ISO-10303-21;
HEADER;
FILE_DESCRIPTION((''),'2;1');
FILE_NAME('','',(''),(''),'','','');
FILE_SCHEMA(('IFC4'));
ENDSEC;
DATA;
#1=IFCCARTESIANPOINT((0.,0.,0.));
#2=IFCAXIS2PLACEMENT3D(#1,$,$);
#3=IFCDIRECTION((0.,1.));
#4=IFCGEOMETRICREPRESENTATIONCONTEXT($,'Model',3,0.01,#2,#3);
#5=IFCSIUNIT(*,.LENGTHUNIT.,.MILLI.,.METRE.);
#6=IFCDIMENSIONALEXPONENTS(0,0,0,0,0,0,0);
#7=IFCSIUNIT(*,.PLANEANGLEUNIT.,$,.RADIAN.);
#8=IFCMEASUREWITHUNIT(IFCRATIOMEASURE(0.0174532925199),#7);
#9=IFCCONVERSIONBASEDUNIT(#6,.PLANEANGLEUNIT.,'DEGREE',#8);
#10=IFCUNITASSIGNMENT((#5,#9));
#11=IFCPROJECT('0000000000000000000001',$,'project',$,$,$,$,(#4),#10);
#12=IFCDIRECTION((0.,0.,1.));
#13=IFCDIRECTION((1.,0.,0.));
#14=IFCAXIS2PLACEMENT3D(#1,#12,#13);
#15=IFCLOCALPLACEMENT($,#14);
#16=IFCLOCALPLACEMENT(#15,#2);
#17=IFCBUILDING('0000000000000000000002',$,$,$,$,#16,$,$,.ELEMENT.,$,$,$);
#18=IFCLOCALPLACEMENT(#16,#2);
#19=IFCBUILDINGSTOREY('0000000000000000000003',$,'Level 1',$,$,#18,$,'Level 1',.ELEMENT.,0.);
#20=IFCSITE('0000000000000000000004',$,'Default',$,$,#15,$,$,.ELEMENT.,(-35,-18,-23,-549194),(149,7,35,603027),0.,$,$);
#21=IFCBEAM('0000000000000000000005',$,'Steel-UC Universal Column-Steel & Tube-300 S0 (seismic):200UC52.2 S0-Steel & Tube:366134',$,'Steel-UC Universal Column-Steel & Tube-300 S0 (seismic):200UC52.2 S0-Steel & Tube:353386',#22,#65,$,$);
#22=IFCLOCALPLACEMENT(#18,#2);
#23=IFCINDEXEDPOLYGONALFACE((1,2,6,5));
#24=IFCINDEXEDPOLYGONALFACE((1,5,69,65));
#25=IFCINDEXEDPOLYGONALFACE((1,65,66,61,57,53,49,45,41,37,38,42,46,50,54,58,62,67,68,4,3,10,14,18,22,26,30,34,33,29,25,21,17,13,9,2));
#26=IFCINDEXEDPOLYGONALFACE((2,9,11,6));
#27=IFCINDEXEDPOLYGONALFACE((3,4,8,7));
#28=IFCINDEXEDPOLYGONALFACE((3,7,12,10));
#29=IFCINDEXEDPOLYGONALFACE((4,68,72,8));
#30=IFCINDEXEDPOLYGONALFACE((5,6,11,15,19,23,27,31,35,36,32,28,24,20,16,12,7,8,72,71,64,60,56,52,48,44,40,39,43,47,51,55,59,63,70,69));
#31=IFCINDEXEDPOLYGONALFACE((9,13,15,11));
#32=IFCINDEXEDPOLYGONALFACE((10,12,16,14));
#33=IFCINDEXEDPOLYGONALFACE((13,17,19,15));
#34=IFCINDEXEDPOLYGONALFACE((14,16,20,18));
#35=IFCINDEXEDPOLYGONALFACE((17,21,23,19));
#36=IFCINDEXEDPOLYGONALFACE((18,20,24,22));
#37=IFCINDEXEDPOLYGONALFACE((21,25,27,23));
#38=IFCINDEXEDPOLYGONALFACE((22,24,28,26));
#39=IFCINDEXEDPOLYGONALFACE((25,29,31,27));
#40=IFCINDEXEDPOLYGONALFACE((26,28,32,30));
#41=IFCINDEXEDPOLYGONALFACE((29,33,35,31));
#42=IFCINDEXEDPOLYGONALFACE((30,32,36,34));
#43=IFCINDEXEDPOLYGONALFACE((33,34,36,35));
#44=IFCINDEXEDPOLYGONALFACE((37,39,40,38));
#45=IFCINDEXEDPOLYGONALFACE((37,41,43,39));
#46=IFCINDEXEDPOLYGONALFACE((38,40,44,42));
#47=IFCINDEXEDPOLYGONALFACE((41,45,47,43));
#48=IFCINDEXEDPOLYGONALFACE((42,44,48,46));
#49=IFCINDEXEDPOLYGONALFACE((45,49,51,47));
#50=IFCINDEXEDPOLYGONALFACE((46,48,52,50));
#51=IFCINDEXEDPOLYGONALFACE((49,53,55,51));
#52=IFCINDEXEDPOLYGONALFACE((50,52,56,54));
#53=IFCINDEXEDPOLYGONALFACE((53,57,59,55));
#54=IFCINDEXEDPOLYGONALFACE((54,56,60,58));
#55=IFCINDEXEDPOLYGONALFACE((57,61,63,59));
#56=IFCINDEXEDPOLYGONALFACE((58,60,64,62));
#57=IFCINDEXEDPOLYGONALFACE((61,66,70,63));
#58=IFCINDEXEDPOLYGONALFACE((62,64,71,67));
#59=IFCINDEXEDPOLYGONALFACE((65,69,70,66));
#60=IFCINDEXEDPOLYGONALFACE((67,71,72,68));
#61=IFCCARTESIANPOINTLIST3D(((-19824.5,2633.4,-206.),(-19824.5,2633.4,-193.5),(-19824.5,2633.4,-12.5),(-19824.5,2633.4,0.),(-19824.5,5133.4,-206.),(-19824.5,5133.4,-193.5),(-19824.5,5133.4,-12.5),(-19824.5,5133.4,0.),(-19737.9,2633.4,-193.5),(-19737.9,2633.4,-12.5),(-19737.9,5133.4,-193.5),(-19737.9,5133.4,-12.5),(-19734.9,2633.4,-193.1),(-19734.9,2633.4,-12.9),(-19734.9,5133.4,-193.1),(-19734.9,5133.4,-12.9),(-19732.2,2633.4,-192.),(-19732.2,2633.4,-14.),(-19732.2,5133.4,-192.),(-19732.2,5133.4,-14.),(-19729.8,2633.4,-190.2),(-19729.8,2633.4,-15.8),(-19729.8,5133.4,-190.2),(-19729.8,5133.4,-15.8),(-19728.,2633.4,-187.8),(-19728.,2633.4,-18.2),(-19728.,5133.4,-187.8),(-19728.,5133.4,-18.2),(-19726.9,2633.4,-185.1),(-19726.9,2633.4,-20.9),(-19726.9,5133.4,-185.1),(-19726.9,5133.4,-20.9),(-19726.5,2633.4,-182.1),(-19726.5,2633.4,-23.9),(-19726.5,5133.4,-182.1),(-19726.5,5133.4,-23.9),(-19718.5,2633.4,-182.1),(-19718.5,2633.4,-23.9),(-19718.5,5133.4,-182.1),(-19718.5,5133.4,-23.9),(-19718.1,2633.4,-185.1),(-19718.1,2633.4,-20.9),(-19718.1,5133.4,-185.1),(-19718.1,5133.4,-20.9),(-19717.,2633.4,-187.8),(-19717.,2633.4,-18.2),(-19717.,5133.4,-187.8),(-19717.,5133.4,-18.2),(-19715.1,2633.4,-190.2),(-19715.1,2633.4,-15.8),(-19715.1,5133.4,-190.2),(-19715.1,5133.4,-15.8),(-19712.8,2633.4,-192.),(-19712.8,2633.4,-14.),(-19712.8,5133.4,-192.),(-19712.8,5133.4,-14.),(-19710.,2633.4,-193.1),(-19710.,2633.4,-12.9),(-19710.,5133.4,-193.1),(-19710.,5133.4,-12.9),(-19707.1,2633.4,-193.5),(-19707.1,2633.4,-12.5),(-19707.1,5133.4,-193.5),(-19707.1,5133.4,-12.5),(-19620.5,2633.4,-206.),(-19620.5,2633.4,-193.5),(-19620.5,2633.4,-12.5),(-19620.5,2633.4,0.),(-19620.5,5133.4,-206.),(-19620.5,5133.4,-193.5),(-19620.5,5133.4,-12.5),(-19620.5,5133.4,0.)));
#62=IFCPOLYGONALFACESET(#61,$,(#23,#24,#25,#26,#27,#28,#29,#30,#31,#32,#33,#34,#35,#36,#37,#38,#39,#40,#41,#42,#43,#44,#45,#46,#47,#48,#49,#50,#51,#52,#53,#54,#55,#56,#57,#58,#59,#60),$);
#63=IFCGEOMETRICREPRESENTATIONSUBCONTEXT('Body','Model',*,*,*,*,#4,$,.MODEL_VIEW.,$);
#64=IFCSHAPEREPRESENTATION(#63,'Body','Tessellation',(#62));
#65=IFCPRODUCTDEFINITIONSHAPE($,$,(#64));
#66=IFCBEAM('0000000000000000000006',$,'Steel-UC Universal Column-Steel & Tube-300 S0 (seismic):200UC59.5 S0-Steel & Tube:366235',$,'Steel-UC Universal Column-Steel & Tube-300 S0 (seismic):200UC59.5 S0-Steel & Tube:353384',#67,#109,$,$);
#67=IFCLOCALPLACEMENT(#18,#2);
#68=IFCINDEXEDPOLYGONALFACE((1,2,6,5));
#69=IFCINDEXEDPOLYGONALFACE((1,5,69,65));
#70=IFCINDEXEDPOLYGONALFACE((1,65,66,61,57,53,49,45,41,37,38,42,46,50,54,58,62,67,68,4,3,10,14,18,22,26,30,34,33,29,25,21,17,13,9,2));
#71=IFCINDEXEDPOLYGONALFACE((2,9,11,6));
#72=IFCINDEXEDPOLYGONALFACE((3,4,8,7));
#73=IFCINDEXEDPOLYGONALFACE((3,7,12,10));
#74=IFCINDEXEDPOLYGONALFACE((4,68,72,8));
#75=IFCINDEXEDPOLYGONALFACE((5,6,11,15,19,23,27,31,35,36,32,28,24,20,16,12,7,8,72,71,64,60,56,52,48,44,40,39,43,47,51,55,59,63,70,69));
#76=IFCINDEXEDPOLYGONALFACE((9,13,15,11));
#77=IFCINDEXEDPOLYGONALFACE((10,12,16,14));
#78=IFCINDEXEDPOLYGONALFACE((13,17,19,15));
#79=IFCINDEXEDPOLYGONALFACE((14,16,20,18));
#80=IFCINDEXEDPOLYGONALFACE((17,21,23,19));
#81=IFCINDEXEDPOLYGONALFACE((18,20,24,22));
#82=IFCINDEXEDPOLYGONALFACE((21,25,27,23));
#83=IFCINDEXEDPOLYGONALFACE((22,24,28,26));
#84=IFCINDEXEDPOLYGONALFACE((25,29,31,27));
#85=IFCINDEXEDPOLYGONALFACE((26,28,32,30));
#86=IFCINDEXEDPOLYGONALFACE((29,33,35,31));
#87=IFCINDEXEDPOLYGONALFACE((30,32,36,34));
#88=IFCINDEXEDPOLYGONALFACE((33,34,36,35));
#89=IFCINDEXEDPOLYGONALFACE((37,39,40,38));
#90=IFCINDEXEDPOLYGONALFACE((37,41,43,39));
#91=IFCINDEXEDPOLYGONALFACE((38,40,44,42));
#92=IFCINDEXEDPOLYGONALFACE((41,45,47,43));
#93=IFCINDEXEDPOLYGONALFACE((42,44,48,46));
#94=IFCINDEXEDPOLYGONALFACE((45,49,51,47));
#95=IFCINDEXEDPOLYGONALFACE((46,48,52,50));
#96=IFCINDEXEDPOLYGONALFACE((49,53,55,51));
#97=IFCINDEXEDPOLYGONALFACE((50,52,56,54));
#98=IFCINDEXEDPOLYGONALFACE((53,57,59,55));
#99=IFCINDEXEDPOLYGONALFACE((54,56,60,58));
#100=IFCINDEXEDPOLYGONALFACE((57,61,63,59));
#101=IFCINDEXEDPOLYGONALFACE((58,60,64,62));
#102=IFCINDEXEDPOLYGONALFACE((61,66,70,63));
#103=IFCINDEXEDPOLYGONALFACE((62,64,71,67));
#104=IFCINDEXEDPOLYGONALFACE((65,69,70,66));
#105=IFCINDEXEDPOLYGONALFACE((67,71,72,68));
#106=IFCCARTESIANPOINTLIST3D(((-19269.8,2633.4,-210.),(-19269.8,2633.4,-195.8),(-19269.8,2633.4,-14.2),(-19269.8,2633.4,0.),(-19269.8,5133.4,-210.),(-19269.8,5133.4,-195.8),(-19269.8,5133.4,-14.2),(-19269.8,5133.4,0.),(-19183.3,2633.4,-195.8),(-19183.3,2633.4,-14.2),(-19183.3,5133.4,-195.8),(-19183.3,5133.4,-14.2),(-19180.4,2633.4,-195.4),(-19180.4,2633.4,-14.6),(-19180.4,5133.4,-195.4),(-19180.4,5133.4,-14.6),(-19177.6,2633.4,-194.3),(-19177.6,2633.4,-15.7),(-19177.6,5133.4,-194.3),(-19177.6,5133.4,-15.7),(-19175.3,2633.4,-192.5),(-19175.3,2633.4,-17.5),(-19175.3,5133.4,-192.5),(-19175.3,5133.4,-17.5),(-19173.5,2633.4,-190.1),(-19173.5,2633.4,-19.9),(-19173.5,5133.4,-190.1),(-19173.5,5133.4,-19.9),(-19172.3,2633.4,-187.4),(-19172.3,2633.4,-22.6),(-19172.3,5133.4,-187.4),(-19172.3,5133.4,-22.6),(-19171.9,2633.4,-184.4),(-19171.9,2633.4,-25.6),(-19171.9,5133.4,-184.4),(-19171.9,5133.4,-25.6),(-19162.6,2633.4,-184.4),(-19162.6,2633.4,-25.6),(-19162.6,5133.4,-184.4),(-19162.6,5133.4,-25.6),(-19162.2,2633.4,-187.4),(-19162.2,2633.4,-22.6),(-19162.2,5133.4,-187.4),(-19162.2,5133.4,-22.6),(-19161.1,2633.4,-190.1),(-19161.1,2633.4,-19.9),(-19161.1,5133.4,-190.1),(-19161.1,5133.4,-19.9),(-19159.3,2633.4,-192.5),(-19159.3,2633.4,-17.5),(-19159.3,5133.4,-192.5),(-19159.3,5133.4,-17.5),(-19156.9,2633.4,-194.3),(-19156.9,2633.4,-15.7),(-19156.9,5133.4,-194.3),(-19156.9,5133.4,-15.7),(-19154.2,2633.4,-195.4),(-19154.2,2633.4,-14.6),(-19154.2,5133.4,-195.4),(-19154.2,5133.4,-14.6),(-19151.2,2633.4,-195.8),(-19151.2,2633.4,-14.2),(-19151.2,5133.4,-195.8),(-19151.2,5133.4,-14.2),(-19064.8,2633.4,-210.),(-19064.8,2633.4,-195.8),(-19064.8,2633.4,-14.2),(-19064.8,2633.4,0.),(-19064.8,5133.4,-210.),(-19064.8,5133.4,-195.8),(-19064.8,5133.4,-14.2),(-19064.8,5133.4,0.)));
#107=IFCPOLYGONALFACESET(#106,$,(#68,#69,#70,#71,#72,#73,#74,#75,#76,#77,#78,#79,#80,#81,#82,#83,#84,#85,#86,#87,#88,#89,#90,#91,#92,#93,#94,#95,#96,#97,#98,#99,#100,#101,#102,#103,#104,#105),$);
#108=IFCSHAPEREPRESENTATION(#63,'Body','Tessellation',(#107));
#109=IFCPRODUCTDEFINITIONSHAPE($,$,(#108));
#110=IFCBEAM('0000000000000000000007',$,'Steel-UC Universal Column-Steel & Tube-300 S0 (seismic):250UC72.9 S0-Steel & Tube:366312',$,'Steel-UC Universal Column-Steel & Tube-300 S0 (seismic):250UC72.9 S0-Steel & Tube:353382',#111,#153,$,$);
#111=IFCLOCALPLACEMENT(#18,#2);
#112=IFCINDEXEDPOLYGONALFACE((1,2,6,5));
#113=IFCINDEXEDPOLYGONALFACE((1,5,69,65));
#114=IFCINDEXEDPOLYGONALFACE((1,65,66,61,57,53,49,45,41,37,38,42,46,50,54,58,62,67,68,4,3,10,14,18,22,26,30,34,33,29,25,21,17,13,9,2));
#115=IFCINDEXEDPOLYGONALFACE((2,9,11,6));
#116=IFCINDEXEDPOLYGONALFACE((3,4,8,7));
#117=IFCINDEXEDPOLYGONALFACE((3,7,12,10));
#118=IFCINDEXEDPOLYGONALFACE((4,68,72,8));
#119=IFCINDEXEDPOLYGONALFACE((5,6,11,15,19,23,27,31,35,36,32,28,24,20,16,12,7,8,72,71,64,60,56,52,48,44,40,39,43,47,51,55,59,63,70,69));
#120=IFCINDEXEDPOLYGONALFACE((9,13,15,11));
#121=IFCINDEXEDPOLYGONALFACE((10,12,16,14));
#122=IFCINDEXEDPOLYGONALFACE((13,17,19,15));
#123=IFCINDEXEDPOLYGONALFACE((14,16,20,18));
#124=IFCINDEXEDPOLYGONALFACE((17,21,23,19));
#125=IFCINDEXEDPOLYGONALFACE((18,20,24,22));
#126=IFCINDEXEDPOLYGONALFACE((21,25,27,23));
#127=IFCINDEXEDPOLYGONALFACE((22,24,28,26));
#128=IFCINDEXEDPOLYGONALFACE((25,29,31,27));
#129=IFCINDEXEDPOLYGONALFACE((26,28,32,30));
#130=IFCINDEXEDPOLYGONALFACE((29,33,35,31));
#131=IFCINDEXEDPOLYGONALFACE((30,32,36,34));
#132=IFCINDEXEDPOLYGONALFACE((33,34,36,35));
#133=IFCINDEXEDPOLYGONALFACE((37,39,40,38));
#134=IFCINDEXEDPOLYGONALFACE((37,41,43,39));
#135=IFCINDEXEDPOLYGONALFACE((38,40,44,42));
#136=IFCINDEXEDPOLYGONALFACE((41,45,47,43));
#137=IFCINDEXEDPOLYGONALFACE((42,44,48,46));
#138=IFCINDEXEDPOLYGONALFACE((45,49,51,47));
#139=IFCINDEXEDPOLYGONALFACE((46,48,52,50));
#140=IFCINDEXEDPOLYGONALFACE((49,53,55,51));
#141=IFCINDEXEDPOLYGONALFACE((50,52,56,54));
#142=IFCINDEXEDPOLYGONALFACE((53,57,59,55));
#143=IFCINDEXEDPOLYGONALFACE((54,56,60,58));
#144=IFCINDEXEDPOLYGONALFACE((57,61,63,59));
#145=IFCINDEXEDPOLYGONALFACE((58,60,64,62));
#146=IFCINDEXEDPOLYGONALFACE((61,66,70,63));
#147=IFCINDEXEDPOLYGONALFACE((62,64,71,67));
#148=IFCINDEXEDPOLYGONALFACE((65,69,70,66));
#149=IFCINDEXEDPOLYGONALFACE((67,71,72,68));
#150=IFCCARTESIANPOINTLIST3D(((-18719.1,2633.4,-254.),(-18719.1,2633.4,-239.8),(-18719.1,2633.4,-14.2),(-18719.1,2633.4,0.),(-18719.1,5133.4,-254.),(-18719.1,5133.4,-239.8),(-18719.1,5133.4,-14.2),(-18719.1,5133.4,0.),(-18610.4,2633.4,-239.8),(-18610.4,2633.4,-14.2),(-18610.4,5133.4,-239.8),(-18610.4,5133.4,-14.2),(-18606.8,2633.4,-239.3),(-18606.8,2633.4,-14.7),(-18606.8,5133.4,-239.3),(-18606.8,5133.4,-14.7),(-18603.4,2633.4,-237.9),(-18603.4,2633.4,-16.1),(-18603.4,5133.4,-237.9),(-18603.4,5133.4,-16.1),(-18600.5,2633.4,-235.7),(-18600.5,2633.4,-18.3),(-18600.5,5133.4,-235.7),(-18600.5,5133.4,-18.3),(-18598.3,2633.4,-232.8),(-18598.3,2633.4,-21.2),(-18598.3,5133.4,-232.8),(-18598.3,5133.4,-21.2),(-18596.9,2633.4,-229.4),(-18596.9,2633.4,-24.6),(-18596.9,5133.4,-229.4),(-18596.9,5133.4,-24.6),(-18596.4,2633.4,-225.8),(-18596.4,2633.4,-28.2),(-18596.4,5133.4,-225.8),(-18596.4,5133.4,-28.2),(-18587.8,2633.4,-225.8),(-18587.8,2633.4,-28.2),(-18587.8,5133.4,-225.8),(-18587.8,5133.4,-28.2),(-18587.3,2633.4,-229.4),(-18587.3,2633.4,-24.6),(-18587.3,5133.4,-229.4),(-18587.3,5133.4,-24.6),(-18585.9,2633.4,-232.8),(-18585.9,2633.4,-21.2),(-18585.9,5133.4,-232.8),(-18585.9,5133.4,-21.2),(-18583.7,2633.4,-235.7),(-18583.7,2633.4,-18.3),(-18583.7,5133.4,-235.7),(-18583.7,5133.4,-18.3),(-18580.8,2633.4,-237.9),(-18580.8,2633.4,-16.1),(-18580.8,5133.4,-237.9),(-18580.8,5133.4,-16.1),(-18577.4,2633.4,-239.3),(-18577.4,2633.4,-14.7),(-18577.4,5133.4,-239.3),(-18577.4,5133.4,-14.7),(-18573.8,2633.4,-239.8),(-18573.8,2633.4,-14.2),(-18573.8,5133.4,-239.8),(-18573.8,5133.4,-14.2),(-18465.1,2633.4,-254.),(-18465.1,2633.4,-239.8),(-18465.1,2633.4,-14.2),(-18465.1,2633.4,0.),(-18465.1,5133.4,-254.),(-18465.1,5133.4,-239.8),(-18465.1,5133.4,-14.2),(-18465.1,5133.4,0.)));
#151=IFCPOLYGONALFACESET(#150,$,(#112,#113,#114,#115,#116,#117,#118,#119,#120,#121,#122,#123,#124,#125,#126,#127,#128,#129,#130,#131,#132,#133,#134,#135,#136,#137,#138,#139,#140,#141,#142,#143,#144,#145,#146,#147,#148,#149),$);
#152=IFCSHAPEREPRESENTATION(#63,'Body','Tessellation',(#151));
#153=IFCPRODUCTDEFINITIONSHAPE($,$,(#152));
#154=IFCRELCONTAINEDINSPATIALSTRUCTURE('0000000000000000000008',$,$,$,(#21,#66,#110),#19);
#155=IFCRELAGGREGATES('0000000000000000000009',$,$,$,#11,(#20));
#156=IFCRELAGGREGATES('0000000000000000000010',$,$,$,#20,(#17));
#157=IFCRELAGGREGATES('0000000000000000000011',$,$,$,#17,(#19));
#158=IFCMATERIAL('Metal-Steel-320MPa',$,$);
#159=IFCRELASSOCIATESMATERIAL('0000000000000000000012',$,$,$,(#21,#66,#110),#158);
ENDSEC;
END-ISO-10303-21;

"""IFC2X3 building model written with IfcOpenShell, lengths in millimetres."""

from ifc_helpers import new_model, entity, si_unit, converted_unit, direction, frame, frame_2d, origin, origin_with_axes, place, context, subcontext, project, spatial, polyline, circle_curve, parameter, trimmed, segment, composite_curve, outline, extrude, material, element, save


model = new_model("IFC2X3")

# Units and contexts
model_context = context("Model", 3, precision=0.01, world=origin(), true_north=direction((0.0, 1.0)))
body_context = subcontext(model_context, "Body", "Model", "MODEL_VIEW")
ifc_project = project(units=[si_unit("LENGTHUNIT", "METRE", prefix="MILLI"), converted_unit("PLANEANGLEUNIT", "DEGREE", entity("IfcRatioMeasure", 0.0174532925199), si_unit("PLANEANGLEUNIT", "RADIAN"), dimensions=[0, 0, 0, 0, 0, 0, 0])], contexts=[model_context])

# Site, building, storey
site_placement = place(None, origin_with_axes())
site = spatial("IfcSite", under=ifc_project, at=site_placement, Name="Default", CompositionType="ELEMENT", RefLatitude=(-35, -18, -23, -549194), RefLongitude=(149, 7, 35, 603027), RefElevation=0.0)
building_placement = place(site_placement, origin())
building = spatial("IfcBuilding", under=site, at=building_placement, CompositionType="ELEMENT")
storey_placement = place(building_placement, origin())
storey = spatial("IfcBuildingStorey", under=building, at=storey_placement, Name="Level 1", LongName="Level 1", CompositionType="ELEMENT", Elevation=0.0)

# Beams
ifc_material_1 = material(Name="Metal-Steel-320MPa")
beam_1_placement = place(storey_placement, frame((-19722.5, 5133.4, 0.0), z_axis=(0.0, 0.0, 1.0), x_axis=(0.0, -1.0, 0.0)))
element("IfcBeam", 1, at=beam_1_placement, inside=storey, material=ifc_material_1, Name="Steel-UC Universal Column-Steel & Tube-300 S0 (seismic):200UC52.2 S0-Steel & Tube:366134", ObjectType="Steel-UC Universal Column-Steel & Tube-300 S0 (seismic):200UC52.2 S0-Steel & Tube:353386", context=body_context, shape_type="SweptSolid", body=[
    extrude(outline(composite_curve([segment(polyline([(90.5, -102.0), (103.0, -102.0)]), True, "CONTINUOUS"), segment(polyline([(103.0, -102.0), (103.0, 102.0)]), True, "CONTINUOUS"), segment(polyline([(103.0, 102.0), (90.5, 102.0)]), True, "CONTINUOUS"), segment(polyline([(90.5, 102.0), (90.5, 15.4)]), True, "CONTINUOUS"), segment(trimmed(circle_curve(frame_2d((79.1, 15.4), x_axis=(1.0, 0.0)), 11.4), [parameter(270.0)], [parameter(0.0)], True, "PARAMETER"), False, "CONTINUOUS"), segment(polyline([(79.1, 4.0), (-79.1, 4.0)]), True, "CONTINUOUS"), segment(trimmed(circle_curve(frame_2d((-79.1, 15.4), x_axis=(0.0, -1.0)), 11.4), [parameter(270.0)], [parameter(0.0)], True, "PARAMETER"), False, "CONTINUOUS"), segment(polyline([(-90.5, 15.4), (-90.5, 102.0)]), True, "CONTINUOUS"), segment(polyline([(-90.5, 102.0), (-103.0, 102.0)]), True, "CONTINUOUS"), segment(polyline([(-103.0, 102.0), (-103.0, -102.0)]), True, "CONTINUOUS"), segment(polyline([(-103.0, -102.0), (-90.5, -102.0)]), True, "CONTINUOUS"), segment(polyline([(-90.5, -102.0), (-90.5, -15.4)]), True, "CONTINUOUS"), segment(trimmed(circle_curve(frame_2d((-79.1, -15.4), x_axis=(-1.0, 0.0)), 11.4), [parameter(270.0)], [parameter(0.0)], True, "PARAMETER"), False, "CONTINUOUS"), segment(polyline([(-79.1, -4.0), (79.1, -4.0)]), True, "CONTINUOUS"), segment(trimmed(circle_curve(frame_2d((79.1, -15.4), x_axis=(0.0, 1.0)), 11.4), [parameter(270.0)], [parameter(0.0)], True, "PARAMETER"), False, "CONTINUOUS"), segment(polyline([(90.5, -15.4), (90.5, -102.0)]), True, "CONTINUOUS")], self_intersect=False)), frame((0.0, 0.0, -103.0), z_axis=(1.0, 0.0, 0.0), x_axis=(0.0, 0.0, -1.0)), (0.0, 0.0, 1.0), 2500.0),
])
beam_2_placement = place(storey_placement, frame((-19167.3, 5133.4, 0.0), z_axis=(0.0, 0.0, 1.0), x_axis=(0.0, -1.0, 0.0)))
element("IfcBeam", 2, at=beam_2_placement, inside=storey, material=ifc_material_1, Name="Steel-UC Universal Column-Steel & Tube-300 S0 (seismic):200UC59.5 S0-Steel & Tube:366235", ObjectType="Steel-UC Universal Column-Steel & Tube-300 S0 (seismic):200UC59.5 S0-Steel & Tube:353384", context=body_context, shape_type="SweptSolid", body=[
    extrude(outline(composite_curve([segment(polyline([(90.8, -102.5), (105.0, -102.5)]), True, "CONTINUOUS"), segment(polyline([(105.0, -102.5), (105.0, 102.5)]), True, "CONTINUOUS"), segment(polyline([(105.0, 102.5), (90.8, 102.5)]), True, "CONTINUOUS"), segment(polyline([(90.8, 102.5), (90.8, 16.1)]), True, "CONTINUOUS"), segment(trimmed(circle_curve(frame_2d((79.4, 16.1), x_axis=(1.0, 0.0)), 11.4), [parameter(270.0)], [parameter(0.0)], True, "PARAMETER"), False, "CONTINUOUS"), segment(polyline([(79.4, 4.7), (-79.4, 4.7)]), True, "CONTINUOUS"), segment(trimmed(circle_curve(frame_2d((-79.4, 16.1), x_axis=(0.0, -1.0)), 11.4), [parameter(270.0)], [parameter(0.0)], True, "PARAMETER"), False, "CONTINUOUS"), segment(polyline([(-90.8, 16.1), (-90.8, 102.5)]), True, "CONTINUOUS"), segment(polyline([(-90.8, 102.5), (-105.0, 102.5)]), True, "CONTINUOUS"), segment(polyline([(-105.0, 102.5), (-105.0, -102.5)]), True, "CONTINUOUS"), segment(polyline([(-105.0, -102.5), (-90.8, -102.5)]), True, "CONTINUOUS"), segment(polyline([(-90.8, -102.5), (-90.8, -16.1)]), True, "CONTINUOUS"), segment(trimmed(circle_curve(frame_2d((-79.4, -16.1), x_axis=(-1.0, 0.0)), 11.4), [parameter(270.0)], [parameter(0.0)], True, "PARAMETER"), False, "CONTINUOUS"), segment(polyline([(-79.4, -4.7), (79.4, -4.7)]), True, "CONTINUOUS"), segment(trimmed(circle_curve(frame_2d((79.4, -16.1), x_axis=(0.0, 1.0)), 11.4), [parameter(270.0)], [parameter(0.0)], True, "PARAMETER"), False, "CONTINUOUS"), segment(polyline([(90.8, -16.1), (90.8, -102.5)]), True, "CONTINUOUS")], self_intersect=False)), frame((0.0, 0.0, -105.0), z_axis=(1.0, 0.0, 0.0), x_axis=(0.0, 0.0, -1.0)), (0.0, 0.0, 1.0), 2500.0),
])
beam_3_placement = place(storey_placement, frame((-18592.1, 5133.4, 0.0), z_axis=(0.0, 0.0, 1.0), x_axis=(0.0, -1.0, 0.0)))
element("IfcBeam", 3, at=beam_3_placement, inside=storey, material=ifc_material_1, Name="Steel-UC Universal Column-Steel & Tube-300 S0 (seismic):250UC72.9 S0-Steel & Tube:366312", ObjectType="Steel-UC Universal Column-Steel & Tube-300 S0 (seismic):250UC72.9 S0-Steel & Tube:353382", context=body_context, shape_type="SweptSolid", body=[
    extrude(outline(composite_curve([segment(polyline([(112.8, -127.0), (127.0, -127.0)]), True, "CONTINUOUS"), segment(polyline([(127.0, -127.0), (127.0, 127.0)]), True, "CONTINUOUS"), segment(polyline([(127.0, 127.0), (112.8, 127.0)]), True, "CONTINUOUS"), segment(polyline([(112.8, 127.0), (112.8, 18.3)]), True, "CONTINUOUS"), segment(trimmed(circle_curve(frame_2d((98.8, 18.3), x_axis=(1.0, 0.0)), 14.0), [parameter(270.0)], [parameter(0.0)], True, "PARAMETER"), False, "CONTINUOUS"), segment(polyline([(98.8, 4.3), (-98.8, 4.3)]), True, "CONTINUOUS"), segment(trimmed(circle_curve(frame_2d((-98.8, 18.3), x_axis=(0.0, -1.0)), 14.0), [parameter(270.0)], [parameter(0.0)], True, "PARAMETER"), False, "CONTINUOUS"), segment(polyline([(-112.8, 18.3), (-112.8, 127.0)]), True, "CONTINUOUS"), segment(polyline([(-112.8, 127.0), (-127.0, 127.0)]), True, "CONTINUOUS"), segment(polyline([(-127.0, 127.0), (-127.0, -127.0)]), True, "CONTINUOUS"), segment(polyline([(-127.0, -127.0), (-112.8, -127.0)]), True, "CONTINUOUS"), segment(polyline([(-112.8, -127.0), (-112.8, -18.3)]), True, "CONTINUOUS"), segment(trimmed(circle_curve(frame_2d((-98.8, -18.3), x_axis=(-1.0, 0.0)), 14.0), [parameter(270.0)], [parameter(0.0)], True, "PARAMETER"), False, "CONTINUOUS"), segment(polyline([(-98.8, -4.3), (98.8, -4.3)]), True, "CONTINUOUS"), segment(trimmed(circle_curve(frame_2d((98.8, -18.3), x_axis=(0.0, 1.0)), 14.0), [parameter(270.0)], [parameter(0.0)], True, "PARAMETER"), False, "CONTINUOUS"), segment(polyline([(112.8, -18.3), (112.8, -127.0)]), True, "CONTINUOUS")], self_intersect=False)), frame((0.0, 0.0, -127.0), z_axis=(1.0, 0.0, 0.0), x_axis=(0.0, 0.0, -1.0)), (0.0, 0.0, 1.0), 2500.0),
])

save(model, "model.ifc")
